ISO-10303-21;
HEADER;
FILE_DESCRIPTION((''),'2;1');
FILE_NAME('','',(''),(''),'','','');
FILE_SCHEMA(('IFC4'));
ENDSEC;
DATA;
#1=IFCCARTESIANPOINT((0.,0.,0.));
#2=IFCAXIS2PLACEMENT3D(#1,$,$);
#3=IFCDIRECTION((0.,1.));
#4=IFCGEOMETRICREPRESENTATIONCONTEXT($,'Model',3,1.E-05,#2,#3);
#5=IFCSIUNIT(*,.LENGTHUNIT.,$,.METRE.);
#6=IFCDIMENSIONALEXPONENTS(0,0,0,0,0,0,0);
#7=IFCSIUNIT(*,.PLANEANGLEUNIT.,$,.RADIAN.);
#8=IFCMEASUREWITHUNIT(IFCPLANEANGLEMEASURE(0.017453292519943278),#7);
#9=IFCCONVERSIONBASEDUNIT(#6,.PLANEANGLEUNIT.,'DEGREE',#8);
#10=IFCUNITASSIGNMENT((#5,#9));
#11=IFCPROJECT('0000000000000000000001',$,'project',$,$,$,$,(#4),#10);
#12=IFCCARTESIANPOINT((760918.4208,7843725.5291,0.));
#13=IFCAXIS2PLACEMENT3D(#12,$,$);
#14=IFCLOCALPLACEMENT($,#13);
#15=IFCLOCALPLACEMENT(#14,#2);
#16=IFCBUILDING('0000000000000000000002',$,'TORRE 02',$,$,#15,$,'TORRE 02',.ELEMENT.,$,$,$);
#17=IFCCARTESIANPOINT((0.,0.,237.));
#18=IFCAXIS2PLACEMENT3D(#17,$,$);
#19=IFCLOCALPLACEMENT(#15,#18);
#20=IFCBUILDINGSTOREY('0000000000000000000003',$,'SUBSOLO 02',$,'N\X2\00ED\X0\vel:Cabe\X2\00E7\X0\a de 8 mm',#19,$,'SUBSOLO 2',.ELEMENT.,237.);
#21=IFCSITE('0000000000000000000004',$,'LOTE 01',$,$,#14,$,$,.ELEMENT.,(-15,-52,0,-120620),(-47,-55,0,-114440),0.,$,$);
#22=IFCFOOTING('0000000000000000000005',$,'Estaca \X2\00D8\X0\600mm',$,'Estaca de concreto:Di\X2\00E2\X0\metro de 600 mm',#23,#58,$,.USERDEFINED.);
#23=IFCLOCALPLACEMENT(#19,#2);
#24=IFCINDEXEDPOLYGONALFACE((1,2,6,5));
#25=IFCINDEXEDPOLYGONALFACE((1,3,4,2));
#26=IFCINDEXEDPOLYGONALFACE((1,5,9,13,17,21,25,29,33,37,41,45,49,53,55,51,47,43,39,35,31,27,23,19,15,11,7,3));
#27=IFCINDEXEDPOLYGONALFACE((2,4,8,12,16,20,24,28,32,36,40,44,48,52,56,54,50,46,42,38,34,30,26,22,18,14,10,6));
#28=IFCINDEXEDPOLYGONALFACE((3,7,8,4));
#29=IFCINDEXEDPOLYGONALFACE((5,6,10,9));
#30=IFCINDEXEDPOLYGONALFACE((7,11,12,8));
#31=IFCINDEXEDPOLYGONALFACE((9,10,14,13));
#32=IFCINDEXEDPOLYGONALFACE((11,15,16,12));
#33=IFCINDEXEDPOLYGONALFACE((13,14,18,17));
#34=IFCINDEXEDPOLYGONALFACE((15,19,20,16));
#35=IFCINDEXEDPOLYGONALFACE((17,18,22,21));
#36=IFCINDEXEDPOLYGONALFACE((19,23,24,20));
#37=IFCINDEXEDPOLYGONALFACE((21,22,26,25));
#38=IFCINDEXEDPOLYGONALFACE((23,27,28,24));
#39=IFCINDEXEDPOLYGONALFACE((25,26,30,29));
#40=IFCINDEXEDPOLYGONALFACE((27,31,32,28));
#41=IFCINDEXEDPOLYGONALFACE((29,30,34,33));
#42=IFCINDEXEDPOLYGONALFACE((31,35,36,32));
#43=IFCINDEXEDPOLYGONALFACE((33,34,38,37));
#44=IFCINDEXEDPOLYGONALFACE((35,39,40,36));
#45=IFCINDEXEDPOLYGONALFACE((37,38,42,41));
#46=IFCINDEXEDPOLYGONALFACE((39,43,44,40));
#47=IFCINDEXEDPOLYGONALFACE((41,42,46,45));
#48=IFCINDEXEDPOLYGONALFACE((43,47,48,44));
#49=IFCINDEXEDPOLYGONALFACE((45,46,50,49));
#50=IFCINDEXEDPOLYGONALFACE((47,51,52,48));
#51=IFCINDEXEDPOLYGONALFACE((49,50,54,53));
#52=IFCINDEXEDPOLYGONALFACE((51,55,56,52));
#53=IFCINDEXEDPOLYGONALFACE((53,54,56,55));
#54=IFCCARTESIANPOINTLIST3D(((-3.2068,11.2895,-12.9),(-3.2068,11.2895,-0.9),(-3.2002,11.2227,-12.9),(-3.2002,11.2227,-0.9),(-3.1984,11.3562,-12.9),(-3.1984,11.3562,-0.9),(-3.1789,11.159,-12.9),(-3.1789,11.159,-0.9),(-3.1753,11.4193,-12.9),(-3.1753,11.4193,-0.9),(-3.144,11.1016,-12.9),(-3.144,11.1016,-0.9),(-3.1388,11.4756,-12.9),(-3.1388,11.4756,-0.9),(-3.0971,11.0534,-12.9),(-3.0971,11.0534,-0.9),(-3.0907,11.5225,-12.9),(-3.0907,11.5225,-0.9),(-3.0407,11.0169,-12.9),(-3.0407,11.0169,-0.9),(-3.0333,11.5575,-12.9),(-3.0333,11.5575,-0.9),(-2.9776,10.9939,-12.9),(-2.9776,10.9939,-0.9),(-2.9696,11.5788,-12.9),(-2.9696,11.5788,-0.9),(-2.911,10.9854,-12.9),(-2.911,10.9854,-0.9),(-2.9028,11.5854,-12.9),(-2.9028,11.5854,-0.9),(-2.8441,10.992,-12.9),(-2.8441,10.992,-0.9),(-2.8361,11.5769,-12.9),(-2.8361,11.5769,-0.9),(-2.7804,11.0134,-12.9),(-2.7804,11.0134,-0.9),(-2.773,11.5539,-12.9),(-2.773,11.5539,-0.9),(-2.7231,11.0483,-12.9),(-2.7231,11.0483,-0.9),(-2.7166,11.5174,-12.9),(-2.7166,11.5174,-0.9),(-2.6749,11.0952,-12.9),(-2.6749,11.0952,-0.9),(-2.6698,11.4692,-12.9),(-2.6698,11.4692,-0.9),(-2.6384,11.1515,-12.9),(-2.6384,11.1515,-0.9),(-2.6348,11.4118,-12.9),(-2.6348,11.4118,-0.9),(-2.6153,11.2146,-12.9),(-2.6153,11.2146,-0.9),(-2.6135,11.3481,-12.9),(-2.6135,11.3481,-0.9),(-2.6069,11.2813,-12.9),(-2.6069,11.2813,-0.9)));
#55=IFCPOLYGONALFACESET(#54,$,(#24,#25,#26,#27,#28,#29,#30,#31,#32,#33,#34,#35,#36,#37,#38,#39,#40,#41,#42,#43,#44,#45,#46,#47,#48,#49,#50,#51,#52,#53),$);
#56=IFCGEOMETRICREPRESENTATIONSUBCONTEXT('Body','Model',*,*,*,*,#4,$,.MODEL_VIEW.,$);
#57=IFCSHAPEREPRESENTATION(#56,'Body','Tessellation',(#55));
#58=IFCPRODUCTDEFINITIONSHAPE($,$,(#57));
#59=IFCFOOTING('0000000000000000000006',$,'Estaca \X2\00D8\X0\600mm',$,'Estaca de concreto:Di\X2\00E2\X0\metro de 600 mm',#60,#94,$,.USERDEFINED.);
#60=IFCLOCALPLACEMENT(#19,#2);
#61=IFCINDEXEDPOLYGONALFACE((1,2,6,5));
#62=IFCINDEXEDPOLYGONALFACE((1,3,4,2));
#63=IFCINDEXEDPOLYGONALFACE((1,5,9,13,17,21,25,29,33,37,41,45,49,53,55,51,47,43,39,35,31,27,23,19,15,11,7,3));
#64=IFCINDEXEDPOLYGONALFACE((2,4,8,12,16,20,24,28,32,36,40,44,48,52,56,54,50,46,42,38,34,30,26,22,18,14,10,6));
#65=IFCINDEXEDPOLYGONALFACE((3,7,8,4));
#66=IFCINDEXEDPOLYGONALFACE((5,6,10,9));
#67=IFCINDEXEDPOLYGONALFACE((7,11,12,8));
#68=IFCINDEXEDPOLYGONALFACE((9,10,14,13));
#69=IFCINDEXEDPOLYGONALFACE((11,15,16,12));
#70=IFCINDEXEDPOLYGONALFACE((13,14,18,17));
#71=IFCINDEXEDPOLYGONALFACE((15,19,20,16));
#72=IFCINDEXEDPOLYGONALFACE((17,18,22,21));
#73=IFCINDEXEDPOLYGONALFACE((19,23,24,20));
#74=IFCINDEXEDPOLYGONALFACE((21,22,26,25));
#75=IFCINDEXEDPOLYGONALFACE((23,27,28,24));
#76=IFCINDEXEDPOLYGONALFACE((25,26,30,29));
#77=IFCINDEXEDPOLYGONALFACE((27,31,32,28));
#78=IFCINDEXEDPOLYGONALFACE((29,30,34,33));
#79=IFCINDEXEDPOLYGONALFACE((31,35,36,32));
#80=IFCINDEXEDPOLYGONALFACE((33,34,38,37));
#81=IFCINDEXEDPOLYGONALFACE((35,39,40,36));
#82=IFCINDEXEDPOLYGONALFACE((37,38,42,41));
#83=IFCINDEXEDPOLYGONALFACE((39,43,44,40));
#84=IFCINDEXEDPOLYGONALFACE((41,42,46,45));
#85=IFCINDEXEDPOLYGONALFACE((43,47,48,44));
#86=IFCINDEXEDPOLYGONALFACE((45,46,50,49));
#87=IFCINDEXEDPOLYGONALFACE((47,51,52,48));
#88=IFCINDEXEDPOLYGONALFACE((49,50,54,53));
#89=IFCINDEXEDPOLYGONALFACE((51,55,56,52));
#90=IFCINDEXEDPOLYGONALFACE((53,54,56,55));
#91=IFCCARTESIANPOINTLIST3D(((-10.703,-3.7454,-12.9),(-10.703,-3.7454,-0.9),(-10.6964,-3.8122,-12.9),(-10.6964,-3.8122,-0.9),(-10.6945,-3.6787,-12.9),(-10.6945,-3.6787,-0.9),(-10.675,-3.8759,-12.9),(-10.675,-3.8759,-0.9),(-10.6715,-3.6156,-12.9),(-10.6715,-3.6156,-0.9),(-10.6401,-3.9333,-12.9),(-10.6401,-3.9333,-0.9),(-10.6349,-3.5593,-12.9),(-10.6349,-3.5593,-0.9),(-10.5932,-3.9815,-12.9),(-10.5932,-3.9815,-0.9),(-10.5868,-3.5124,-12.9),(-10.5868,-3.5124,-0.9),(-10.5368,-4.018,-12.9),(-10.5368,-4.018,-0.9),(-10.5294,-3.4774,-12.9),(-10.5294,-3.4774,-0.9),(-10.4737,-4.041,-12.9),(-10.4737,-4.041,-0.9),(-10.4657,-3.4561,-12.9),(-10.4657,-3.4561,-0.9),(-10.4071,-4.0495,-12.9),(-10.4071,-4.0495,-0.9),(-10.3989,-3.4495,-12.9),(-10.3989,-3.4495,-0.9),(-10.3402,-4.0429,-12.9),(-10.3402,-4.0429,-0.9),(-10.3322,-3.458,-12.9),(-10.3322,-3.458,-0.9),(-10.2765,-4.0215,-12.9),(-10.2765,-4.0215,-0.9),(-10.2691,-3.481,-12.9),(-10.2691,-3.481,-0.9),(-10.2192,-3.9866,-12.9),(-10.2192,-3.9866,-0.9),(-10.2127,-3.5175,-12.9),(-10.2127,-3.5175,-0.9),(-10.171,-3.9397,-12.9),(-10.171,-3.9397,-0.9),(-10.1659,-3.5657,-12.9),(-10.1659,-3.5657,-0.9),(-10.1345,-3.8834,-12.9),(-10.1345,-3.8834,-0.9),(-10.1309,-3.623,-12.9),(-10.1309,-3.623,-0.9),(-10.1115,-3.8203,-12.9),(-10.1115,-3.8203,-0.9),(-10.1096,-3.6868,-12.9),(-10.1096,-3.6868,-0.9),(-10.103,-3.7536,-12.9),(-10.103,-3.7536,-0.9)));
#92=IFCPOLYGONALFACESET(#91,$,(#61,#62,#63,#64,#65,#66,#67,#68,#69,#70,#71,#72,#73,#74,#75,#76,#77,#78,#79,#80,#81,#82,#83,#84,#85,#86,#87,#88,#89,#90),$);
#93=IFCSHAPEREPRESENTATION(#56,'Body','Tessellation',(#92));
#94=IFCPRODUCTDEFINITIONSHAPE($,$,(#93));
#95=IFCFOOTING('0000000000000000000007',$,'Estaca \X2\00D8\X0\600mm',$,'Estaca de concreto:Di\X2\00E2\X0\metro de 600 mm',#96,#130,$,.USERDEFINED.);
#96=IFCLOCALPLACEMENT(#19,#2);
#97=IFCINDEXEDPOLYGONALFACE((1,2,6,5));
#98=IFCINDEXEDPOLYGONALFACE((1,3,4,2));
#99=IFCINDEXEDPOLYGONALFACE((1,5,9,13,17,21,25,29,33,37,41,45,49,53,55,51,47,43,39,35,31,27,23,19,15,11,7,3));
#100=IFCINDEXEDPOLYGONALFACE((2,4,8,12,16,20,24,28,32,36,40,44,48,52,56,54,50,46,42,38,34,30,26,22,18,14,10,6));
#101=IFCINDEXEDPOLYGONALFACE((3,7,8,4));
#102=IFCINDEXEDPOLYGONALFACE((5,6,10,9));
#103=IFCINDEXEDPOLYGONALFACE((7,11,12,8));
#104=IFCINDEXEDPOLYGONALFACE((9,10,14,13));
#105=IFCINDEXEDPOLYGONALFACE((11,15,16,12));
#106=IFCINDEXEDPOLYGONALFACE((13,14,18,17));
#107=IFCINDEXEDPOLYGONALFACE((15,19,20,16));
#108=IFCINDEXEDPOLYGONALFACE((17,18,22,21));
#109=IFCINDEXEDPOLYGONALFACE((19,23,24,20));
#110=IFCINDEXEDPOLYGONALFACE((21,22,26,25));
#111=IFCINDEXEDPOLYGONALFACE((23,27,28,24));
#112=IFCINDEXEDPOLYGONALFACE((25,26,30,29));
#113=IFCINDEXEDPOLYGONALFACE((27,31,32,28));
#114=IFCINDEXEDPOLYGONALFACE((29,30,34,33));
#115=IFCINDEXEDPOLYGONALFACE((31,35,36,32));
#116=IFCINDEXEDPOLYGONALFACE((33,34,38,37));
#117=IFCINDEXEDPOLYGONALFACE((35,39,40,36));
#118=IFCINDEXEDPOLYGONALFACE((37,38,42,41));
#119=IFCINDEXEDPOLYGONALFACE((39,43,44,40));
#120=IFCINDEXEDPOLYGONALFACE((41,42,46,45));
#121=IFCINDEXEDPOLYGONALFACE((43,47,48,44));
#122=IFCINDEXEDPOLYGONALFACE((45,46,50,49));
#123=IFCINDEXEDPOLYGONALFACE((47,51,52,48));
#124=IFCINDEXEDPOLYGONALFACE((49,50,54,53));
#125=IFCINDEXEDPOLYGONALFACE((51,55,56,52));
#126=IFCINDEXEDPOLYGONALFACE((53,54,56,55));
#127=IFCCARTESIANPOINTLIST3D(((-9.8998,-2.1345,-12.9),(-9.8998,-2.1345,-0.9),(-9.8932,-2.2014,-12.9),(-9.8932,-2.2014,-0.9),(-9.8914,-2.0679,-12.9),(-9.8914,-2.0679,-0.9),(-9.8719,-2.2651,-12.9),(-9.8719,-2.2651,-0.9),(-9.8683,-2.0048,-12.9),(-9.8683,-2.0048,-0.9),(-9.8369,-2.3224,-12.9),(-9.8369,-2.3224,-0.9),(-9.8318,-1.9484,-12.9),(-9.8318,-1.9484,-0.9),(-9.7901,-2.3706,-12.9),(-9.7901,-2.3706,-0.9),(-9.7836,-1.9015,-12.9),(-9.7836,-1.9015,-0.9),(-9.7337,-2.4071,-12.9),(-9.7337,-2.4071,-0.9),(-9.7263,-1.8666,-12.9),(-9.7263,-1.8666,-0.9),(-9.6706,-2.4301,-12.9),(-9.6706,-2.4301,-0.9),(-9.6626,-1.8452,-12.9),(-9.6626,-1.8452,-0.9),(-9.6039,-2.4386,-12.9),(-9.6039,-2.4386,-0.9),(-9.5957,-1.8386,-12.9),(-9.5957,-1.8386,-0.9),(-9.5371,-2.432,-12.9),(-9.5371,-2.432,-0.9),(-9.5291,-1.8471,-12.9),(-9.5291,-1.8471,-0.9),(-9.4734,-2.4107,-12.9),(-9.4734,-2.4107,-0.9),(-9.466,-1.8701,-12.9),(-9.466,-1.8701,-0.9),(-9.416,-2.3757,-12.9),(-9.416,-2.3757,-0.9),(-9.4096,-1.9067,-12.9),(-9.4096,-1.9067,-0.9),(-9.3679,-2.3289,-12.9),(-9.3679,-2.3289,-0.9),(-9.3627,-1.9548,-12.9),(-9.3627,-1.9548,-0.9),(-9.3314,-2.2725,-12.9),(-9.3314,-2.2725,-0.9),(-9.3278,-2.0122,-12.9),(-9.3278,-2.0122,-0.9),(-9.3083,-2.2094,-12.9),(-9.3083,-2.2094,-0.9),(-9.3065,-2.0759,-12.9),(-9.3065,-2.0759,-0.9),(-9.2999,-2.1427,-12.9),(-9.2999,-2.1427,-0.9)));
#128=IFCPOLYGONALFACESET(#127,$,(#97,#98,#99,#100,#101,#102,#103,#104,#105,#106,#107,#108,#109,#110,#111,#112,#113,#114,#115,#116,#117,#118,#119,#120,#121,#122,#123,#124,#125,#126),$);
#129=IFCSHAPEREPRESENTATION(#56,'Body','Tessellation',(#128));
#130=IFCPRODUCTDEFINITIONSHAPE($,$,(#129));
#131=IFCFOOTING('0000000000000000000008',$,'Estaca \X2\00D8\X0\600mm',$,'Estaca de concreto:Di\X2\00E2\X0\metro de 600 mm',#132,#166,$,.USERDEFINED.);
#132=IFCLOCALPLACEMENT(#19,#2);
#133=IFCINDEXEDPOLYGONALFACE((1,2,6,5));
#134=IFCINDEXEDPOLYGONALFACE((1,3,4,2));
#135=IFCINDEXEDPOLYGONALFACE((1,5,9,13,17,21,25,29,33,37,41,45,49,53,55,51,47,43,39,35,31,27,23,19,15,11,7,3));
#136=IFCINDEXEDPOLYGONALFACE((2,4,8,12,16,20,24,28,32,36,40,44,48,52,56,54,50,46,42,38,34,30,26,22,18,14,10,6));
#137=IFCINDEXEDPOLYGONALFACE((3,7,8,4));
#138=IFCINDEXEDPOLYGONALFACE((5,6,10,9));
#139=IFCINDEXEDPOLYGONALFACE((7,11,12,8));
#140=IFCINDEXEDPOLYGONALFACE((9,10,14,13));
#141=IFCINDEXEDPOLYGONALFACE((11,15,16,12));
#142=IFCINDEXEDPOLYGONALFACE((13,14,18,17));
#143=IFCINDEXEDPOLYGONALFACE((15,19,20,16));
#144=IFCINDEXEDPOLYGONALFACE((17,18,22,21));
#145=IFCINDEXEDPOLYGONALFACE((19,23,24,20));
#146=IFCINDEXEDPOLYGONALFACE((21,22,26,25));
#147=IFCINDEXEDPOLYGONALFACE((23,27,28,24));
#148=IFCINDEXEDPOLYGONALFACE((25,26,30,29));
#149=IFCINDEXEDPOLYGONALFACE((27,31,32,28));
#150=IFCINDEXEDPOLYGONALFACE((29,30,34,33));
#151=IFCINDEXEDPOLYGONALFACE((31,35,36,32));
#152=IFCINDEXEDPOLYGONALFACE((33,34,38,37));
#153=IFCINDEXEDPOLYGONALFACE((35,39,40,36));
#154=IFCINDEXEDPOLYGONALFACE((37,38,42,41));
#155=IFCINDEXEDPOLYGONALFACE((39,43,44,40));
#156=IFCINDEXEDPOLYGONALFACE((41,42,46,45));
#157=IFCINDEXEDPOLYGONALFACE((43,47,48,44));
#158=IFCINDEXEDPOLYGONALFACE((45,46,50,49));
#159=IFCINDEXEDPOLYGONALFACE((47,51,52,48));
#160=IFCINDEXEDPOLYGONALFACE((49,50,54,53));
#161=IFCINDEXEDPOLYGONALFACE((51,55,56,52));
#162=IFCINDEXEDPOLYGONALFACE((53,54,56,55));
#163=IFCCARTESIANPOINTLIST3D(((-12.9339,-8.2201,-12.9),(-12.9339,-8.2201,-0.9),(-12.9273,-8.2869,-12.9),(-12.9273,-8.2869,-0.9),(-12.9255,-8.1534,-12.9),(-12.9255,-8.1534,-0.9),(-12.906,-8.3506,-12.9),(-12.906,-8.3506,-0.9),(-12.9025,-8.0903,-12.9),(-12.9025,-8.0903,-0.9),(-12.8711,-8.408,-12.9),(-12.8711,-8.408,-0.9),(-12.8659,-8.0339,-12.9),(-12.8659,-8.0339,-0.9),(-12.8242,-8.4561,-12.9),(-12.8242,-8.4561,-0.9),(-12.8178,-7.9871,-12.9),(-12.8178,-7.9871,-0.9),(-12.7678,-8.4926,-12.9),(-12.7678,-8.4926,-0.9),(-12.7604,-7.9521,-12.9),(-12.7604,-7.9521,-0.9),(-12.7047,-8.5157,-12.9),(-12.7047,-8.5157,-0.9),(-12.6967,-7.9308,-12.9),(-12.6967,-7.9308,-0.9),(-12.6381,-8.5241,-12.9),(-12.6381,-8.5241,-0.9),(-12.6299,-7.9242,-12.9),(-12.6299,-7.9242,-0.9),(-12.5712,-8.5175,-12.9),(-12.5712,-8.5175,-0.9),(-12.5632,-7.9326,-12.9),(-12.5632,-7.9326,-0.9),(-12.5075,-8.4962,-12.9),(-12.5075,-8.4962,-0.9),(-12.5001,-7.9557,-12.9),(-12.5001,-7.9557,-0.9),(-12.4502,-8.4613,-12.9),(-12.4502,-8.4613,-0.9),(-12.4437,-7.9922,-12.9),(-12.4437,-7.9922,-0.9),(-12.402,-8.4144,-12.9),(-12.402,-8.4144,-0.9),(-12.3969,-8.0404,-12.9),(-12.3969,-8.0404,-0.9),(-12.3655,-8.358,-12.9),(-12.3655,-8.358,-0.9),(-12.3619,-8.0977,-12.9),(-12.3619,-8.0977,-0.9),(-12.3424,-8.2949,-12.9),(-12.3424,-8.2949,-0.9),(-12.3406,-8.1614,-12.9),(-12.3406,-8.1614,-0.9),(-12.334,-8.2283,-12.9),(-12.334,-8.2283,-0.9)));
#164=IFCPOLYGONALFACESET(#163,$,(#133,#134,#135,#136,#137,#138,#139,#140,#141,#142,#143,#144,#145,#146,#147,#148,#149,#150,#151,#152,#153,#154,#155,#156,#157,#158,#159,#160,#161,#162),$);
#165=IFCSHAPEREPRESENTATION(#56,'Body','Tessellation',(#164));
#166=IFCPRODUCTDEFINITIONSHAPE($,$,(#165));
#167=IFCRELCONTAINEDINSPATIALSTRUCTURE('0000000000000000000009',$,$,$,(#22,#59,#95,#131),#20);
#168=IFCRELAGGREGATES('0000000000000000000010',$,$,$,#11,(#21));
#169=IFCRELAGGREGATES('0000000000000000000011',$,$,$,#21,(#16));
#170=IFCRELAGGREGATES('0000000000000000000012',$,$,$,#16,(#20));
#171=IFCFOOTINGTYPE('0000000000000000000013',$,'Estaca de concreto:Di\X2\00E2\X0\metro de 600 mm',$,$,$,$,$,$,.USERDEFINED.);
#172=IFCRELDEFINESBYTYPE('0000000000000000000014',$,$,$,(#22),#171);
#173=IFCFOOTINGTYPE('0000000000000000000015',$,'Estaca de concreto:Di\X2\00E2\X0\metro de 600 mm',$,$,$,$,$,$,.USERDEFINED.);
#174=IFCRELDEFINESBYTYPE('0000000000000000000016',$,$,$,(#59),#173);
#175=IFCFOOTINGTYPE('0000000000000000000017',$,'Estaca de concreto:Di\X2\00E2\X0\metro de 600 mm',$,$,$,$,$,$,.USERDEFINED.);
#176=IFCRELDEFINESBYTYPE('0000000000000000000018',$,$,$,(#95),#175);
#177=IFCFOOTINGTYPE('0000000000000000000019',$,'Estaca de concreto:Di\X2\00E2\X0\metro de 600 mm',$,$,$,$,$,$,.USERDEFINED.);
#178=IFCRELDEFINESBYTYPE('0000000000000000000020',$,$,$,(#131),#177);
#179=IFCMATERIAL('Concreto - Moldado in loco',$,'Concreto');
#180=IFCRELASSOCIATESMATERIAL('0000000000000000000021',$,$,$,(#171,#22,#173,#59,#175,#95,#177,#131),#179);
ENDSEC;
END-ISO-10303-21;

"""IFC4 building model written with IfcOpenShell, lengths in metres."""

from ifc_helpers import new_model, entity, si_unit, converted_unit, direction, frame, origin, place, context, subcontext, project, spatial, arc, indexed_curve, outline, extrude, source, transform, mapped, material, type_object, type_shapes, element, save


model = new_model("IFC4")

# Units and contexts
model_context = context("Model", 3, precision=1e-05, world=origin(), true_north=direction((0.0, 1.0)))
body_context = subcontext(model_context, "Body", "Model", "MODEL_VIEW")
ifc_project = project(units=[si_unit("LENGTHUNIT", "METRE"), converted_unit("PLANEANGLEUNIT", "DEGREE", entity("IfcPlaneAngleMeasure", 0.017453292519943278), si_unit("PLANEANGLEUNIT", "RADIAN"), dimensions=[0, 0, 0, 0, 0, 0, 0])], contexts=[model_context])

# Site, building, storey
site_placement = place(None, frame((760918.4208, 7843725.5291, 0.0)))
site = spatial("IfcSite", under=ifc_project, at=site_placement, Name="LOTE 01", CompositionType="ELEMENT", RefLatitude=(-15, -52, 0, -120620), RefLongitude=(-47, -55, 0, -114440), RefElevation=0.0)
building_placement = place(site_placement, origin())
building = spatial("IfcBuilding", under=site, at=building_placement, Name="TORRE 02", LongName="TORRE 02", CompositionType="ELEMENT")
storey_placement = place(building_placement, frame((0.0, 0.0, 237.0)))
storey = spatial("IfcBuildingStorey", under=building, at=storey_placement, Name="SUBSOLO 02", ObjectType="Nível:Cabeça de 8 mm", LongName="SUBSOLO 2", CompositionType="ELEMENT", Elevation=237.0)

# Footings
ifc_material_1 = material(Name="Concreto - Moldado in loco", Category="Concreto")
placement = place(building_placement, frame((0.0, 0.0, 237.0)))
footing_type_1 = type_object("IfcFootingType", Name="Estaca de concreto:Diâmetro de 600 mm", PredefinedType="USERDEFINED", material=ifc_material_1)
shared_shape_1 = source(origin(), body_context, "Body", "SweptSolid", [
    extrude(outline(indexed_curve([(-0.3, 0.0), (0.0, -0.3), (0.3, 0.0), (0.0, 0.3)], segments=[arc(1, 2, 3), arc(3, 4, 1)], self_intersect=False)), frame((-2.9069, 11.2854, -12.0), z_axis=(0.0, 0.0, 1.0), x_axis=(0.446198, 0.894934, 0.0)), (0.0, 0.0, 1.0), 12.0),
])
type_shapes(footing_type_1, [shared_shape_1])
footing_1_placement = place(placement, frame((0.0, 0.0, -0.9)))
element("IfcFooting", 1, at=footing_1_placement, inside=storey, type_object=footing_type_1, material=ifc_material_1, Name="Estaca Ø600mm", ObjectType="Estaca de concreto:Diâmetro de 600 mm", PredefinedType="USERDEFINED", context=body_context, shape_type="MappedRepresentation", body=[
    mapped(shared_shape_1, transform((0.0, 0.0, 0.0), scale=1.0)),
])
footing_type_2 = type_object("IfcFootingType", Name="Estaca de concreto:Diâmetro de 600 mm", PredefinedType="USERDEFINED", material=ifc_material_1)
shared_shape_2 = source(origin(), body_context, "Body", "SweptSolid", [
    extrude(outline(indexed_curve([(-0.3, 0.0), (0.0, -0.3), (0.3, 0.0), (0.0, 0.3)], segments=[arc(1, 2, 3), arc(3, 4, 1)], self_intersect=False)), frame((-10.403, -3.7495, -12.0), z_axis=(0.0, 0.0, 1.0), x_axis=(0.446198, 0.894934, 0.0)), (0.0, 0.0, 1.0), 12.0),
])
type_shapes(footing_type_2, [shared_shape_2])
footing_2_placement = place(placement, frame((0.0, 0.0, -0.9)))
element("IfcFooting", 2, at=footing_2_placement, inside=storey, type_object=footing_type_2, material=ifc_material_1, Name="Estaca Ø600mm", ObjectType="Estaca de concreto:Diâmetro de 600 mm", PredefinedType="USERDEFINED", context=body_context, shape_type="MappedRepresentation", body=[
    mapped(shared_shape_2, transform((0.0, 0.0, 0.0), scale=1.0)),
])
footing_type_3 = type_object("IfcFootingType", Name="Estaca de concreto:Diâmetro de 600 mm", PredefinedType="USERDEFINED", material=ifc_material_1)
shared_shape_3 = source(origin(), body_context, "Body", "SweptSolid", [
    extrude(outline(indexed_curve([(-0.3, 0.0), (0.0, -0.3), (0.3, 0.0), (0.0, 0.3)], segments=[arc(1, 2, 3), arc(3, 4, 1)], self_intersect=False)), frame((-9.5998, -2.1386, -12.0), z_axis=(0.0, 0.0, 1.0), x_axis=(0.446198, 0.894934, 0.0)), (0.0, 0.0, 1.0), 12.0),
])
type_shapes(footing_type_3, [shared_shape_3])
footing_3_placement = place(placement, frame((0.0, 0.0, -0.9)))
element("IfcFooting", 3, at=footing_3_placement, inside=storey, type_object=footing_type_3, material=ifc_material_1, Name="Estaca Ø600mm", ObjectType="Estaca de concreto:Diâmetro de 600 mm", PredefinedType="USERDEFINED", context=body_context, shape_type="MappedRepresentation", body=[
    mapped(shared_shape_3, transform((0.0, 0.0, 0.0), scale=1.0)),
])
footing_type_4 = type_object("IfcFootingType", Name="Estaca de concreto:Diâmetro de 600 mm", PredefinedType="USERDEFINED", material=ifc_material_1)
shared_shape_4 = source(origin(), body_context, "Body", "SweptSolid", [
    extrude(outline(indexed_curve([(-0.3, 0.0), (0.0, -0.3), (0.3, 0.0), (0.0, 0.3)], segments=[arc(1, 2, 3), arc(3, 4, 1)], self_intersect=False)), frame((-12.634, -8.2242, -12.0), z_axis=(0.0, 0.0, 1.0), x_axis=(0.446198, 0.894934, 0.0)), (0.0, 0.0, 1.0), 12.0),
])
type_shapes(footing_type_4, [shared_shape_4])
footing_4_placement = place(placement, frame((0.0, 0.0, -0.9)))
element("IfcFooting", 4, at=footing_4_placement, inside=storey, type_object=footing_type_4, material=ifc_material_1, Name="Estaca Ø600mm", ObjectType="Estaca de concreto:Diâmetro de 600 mm", PredefinedType="USERDEFINED", context=body_context, shape_type="MappedRepresentation", body=[
    mapped(shared_shape_4, transform((0.0, 0.0, 0.0), scale=1.0)),
])

save(model, "model.ifc")
